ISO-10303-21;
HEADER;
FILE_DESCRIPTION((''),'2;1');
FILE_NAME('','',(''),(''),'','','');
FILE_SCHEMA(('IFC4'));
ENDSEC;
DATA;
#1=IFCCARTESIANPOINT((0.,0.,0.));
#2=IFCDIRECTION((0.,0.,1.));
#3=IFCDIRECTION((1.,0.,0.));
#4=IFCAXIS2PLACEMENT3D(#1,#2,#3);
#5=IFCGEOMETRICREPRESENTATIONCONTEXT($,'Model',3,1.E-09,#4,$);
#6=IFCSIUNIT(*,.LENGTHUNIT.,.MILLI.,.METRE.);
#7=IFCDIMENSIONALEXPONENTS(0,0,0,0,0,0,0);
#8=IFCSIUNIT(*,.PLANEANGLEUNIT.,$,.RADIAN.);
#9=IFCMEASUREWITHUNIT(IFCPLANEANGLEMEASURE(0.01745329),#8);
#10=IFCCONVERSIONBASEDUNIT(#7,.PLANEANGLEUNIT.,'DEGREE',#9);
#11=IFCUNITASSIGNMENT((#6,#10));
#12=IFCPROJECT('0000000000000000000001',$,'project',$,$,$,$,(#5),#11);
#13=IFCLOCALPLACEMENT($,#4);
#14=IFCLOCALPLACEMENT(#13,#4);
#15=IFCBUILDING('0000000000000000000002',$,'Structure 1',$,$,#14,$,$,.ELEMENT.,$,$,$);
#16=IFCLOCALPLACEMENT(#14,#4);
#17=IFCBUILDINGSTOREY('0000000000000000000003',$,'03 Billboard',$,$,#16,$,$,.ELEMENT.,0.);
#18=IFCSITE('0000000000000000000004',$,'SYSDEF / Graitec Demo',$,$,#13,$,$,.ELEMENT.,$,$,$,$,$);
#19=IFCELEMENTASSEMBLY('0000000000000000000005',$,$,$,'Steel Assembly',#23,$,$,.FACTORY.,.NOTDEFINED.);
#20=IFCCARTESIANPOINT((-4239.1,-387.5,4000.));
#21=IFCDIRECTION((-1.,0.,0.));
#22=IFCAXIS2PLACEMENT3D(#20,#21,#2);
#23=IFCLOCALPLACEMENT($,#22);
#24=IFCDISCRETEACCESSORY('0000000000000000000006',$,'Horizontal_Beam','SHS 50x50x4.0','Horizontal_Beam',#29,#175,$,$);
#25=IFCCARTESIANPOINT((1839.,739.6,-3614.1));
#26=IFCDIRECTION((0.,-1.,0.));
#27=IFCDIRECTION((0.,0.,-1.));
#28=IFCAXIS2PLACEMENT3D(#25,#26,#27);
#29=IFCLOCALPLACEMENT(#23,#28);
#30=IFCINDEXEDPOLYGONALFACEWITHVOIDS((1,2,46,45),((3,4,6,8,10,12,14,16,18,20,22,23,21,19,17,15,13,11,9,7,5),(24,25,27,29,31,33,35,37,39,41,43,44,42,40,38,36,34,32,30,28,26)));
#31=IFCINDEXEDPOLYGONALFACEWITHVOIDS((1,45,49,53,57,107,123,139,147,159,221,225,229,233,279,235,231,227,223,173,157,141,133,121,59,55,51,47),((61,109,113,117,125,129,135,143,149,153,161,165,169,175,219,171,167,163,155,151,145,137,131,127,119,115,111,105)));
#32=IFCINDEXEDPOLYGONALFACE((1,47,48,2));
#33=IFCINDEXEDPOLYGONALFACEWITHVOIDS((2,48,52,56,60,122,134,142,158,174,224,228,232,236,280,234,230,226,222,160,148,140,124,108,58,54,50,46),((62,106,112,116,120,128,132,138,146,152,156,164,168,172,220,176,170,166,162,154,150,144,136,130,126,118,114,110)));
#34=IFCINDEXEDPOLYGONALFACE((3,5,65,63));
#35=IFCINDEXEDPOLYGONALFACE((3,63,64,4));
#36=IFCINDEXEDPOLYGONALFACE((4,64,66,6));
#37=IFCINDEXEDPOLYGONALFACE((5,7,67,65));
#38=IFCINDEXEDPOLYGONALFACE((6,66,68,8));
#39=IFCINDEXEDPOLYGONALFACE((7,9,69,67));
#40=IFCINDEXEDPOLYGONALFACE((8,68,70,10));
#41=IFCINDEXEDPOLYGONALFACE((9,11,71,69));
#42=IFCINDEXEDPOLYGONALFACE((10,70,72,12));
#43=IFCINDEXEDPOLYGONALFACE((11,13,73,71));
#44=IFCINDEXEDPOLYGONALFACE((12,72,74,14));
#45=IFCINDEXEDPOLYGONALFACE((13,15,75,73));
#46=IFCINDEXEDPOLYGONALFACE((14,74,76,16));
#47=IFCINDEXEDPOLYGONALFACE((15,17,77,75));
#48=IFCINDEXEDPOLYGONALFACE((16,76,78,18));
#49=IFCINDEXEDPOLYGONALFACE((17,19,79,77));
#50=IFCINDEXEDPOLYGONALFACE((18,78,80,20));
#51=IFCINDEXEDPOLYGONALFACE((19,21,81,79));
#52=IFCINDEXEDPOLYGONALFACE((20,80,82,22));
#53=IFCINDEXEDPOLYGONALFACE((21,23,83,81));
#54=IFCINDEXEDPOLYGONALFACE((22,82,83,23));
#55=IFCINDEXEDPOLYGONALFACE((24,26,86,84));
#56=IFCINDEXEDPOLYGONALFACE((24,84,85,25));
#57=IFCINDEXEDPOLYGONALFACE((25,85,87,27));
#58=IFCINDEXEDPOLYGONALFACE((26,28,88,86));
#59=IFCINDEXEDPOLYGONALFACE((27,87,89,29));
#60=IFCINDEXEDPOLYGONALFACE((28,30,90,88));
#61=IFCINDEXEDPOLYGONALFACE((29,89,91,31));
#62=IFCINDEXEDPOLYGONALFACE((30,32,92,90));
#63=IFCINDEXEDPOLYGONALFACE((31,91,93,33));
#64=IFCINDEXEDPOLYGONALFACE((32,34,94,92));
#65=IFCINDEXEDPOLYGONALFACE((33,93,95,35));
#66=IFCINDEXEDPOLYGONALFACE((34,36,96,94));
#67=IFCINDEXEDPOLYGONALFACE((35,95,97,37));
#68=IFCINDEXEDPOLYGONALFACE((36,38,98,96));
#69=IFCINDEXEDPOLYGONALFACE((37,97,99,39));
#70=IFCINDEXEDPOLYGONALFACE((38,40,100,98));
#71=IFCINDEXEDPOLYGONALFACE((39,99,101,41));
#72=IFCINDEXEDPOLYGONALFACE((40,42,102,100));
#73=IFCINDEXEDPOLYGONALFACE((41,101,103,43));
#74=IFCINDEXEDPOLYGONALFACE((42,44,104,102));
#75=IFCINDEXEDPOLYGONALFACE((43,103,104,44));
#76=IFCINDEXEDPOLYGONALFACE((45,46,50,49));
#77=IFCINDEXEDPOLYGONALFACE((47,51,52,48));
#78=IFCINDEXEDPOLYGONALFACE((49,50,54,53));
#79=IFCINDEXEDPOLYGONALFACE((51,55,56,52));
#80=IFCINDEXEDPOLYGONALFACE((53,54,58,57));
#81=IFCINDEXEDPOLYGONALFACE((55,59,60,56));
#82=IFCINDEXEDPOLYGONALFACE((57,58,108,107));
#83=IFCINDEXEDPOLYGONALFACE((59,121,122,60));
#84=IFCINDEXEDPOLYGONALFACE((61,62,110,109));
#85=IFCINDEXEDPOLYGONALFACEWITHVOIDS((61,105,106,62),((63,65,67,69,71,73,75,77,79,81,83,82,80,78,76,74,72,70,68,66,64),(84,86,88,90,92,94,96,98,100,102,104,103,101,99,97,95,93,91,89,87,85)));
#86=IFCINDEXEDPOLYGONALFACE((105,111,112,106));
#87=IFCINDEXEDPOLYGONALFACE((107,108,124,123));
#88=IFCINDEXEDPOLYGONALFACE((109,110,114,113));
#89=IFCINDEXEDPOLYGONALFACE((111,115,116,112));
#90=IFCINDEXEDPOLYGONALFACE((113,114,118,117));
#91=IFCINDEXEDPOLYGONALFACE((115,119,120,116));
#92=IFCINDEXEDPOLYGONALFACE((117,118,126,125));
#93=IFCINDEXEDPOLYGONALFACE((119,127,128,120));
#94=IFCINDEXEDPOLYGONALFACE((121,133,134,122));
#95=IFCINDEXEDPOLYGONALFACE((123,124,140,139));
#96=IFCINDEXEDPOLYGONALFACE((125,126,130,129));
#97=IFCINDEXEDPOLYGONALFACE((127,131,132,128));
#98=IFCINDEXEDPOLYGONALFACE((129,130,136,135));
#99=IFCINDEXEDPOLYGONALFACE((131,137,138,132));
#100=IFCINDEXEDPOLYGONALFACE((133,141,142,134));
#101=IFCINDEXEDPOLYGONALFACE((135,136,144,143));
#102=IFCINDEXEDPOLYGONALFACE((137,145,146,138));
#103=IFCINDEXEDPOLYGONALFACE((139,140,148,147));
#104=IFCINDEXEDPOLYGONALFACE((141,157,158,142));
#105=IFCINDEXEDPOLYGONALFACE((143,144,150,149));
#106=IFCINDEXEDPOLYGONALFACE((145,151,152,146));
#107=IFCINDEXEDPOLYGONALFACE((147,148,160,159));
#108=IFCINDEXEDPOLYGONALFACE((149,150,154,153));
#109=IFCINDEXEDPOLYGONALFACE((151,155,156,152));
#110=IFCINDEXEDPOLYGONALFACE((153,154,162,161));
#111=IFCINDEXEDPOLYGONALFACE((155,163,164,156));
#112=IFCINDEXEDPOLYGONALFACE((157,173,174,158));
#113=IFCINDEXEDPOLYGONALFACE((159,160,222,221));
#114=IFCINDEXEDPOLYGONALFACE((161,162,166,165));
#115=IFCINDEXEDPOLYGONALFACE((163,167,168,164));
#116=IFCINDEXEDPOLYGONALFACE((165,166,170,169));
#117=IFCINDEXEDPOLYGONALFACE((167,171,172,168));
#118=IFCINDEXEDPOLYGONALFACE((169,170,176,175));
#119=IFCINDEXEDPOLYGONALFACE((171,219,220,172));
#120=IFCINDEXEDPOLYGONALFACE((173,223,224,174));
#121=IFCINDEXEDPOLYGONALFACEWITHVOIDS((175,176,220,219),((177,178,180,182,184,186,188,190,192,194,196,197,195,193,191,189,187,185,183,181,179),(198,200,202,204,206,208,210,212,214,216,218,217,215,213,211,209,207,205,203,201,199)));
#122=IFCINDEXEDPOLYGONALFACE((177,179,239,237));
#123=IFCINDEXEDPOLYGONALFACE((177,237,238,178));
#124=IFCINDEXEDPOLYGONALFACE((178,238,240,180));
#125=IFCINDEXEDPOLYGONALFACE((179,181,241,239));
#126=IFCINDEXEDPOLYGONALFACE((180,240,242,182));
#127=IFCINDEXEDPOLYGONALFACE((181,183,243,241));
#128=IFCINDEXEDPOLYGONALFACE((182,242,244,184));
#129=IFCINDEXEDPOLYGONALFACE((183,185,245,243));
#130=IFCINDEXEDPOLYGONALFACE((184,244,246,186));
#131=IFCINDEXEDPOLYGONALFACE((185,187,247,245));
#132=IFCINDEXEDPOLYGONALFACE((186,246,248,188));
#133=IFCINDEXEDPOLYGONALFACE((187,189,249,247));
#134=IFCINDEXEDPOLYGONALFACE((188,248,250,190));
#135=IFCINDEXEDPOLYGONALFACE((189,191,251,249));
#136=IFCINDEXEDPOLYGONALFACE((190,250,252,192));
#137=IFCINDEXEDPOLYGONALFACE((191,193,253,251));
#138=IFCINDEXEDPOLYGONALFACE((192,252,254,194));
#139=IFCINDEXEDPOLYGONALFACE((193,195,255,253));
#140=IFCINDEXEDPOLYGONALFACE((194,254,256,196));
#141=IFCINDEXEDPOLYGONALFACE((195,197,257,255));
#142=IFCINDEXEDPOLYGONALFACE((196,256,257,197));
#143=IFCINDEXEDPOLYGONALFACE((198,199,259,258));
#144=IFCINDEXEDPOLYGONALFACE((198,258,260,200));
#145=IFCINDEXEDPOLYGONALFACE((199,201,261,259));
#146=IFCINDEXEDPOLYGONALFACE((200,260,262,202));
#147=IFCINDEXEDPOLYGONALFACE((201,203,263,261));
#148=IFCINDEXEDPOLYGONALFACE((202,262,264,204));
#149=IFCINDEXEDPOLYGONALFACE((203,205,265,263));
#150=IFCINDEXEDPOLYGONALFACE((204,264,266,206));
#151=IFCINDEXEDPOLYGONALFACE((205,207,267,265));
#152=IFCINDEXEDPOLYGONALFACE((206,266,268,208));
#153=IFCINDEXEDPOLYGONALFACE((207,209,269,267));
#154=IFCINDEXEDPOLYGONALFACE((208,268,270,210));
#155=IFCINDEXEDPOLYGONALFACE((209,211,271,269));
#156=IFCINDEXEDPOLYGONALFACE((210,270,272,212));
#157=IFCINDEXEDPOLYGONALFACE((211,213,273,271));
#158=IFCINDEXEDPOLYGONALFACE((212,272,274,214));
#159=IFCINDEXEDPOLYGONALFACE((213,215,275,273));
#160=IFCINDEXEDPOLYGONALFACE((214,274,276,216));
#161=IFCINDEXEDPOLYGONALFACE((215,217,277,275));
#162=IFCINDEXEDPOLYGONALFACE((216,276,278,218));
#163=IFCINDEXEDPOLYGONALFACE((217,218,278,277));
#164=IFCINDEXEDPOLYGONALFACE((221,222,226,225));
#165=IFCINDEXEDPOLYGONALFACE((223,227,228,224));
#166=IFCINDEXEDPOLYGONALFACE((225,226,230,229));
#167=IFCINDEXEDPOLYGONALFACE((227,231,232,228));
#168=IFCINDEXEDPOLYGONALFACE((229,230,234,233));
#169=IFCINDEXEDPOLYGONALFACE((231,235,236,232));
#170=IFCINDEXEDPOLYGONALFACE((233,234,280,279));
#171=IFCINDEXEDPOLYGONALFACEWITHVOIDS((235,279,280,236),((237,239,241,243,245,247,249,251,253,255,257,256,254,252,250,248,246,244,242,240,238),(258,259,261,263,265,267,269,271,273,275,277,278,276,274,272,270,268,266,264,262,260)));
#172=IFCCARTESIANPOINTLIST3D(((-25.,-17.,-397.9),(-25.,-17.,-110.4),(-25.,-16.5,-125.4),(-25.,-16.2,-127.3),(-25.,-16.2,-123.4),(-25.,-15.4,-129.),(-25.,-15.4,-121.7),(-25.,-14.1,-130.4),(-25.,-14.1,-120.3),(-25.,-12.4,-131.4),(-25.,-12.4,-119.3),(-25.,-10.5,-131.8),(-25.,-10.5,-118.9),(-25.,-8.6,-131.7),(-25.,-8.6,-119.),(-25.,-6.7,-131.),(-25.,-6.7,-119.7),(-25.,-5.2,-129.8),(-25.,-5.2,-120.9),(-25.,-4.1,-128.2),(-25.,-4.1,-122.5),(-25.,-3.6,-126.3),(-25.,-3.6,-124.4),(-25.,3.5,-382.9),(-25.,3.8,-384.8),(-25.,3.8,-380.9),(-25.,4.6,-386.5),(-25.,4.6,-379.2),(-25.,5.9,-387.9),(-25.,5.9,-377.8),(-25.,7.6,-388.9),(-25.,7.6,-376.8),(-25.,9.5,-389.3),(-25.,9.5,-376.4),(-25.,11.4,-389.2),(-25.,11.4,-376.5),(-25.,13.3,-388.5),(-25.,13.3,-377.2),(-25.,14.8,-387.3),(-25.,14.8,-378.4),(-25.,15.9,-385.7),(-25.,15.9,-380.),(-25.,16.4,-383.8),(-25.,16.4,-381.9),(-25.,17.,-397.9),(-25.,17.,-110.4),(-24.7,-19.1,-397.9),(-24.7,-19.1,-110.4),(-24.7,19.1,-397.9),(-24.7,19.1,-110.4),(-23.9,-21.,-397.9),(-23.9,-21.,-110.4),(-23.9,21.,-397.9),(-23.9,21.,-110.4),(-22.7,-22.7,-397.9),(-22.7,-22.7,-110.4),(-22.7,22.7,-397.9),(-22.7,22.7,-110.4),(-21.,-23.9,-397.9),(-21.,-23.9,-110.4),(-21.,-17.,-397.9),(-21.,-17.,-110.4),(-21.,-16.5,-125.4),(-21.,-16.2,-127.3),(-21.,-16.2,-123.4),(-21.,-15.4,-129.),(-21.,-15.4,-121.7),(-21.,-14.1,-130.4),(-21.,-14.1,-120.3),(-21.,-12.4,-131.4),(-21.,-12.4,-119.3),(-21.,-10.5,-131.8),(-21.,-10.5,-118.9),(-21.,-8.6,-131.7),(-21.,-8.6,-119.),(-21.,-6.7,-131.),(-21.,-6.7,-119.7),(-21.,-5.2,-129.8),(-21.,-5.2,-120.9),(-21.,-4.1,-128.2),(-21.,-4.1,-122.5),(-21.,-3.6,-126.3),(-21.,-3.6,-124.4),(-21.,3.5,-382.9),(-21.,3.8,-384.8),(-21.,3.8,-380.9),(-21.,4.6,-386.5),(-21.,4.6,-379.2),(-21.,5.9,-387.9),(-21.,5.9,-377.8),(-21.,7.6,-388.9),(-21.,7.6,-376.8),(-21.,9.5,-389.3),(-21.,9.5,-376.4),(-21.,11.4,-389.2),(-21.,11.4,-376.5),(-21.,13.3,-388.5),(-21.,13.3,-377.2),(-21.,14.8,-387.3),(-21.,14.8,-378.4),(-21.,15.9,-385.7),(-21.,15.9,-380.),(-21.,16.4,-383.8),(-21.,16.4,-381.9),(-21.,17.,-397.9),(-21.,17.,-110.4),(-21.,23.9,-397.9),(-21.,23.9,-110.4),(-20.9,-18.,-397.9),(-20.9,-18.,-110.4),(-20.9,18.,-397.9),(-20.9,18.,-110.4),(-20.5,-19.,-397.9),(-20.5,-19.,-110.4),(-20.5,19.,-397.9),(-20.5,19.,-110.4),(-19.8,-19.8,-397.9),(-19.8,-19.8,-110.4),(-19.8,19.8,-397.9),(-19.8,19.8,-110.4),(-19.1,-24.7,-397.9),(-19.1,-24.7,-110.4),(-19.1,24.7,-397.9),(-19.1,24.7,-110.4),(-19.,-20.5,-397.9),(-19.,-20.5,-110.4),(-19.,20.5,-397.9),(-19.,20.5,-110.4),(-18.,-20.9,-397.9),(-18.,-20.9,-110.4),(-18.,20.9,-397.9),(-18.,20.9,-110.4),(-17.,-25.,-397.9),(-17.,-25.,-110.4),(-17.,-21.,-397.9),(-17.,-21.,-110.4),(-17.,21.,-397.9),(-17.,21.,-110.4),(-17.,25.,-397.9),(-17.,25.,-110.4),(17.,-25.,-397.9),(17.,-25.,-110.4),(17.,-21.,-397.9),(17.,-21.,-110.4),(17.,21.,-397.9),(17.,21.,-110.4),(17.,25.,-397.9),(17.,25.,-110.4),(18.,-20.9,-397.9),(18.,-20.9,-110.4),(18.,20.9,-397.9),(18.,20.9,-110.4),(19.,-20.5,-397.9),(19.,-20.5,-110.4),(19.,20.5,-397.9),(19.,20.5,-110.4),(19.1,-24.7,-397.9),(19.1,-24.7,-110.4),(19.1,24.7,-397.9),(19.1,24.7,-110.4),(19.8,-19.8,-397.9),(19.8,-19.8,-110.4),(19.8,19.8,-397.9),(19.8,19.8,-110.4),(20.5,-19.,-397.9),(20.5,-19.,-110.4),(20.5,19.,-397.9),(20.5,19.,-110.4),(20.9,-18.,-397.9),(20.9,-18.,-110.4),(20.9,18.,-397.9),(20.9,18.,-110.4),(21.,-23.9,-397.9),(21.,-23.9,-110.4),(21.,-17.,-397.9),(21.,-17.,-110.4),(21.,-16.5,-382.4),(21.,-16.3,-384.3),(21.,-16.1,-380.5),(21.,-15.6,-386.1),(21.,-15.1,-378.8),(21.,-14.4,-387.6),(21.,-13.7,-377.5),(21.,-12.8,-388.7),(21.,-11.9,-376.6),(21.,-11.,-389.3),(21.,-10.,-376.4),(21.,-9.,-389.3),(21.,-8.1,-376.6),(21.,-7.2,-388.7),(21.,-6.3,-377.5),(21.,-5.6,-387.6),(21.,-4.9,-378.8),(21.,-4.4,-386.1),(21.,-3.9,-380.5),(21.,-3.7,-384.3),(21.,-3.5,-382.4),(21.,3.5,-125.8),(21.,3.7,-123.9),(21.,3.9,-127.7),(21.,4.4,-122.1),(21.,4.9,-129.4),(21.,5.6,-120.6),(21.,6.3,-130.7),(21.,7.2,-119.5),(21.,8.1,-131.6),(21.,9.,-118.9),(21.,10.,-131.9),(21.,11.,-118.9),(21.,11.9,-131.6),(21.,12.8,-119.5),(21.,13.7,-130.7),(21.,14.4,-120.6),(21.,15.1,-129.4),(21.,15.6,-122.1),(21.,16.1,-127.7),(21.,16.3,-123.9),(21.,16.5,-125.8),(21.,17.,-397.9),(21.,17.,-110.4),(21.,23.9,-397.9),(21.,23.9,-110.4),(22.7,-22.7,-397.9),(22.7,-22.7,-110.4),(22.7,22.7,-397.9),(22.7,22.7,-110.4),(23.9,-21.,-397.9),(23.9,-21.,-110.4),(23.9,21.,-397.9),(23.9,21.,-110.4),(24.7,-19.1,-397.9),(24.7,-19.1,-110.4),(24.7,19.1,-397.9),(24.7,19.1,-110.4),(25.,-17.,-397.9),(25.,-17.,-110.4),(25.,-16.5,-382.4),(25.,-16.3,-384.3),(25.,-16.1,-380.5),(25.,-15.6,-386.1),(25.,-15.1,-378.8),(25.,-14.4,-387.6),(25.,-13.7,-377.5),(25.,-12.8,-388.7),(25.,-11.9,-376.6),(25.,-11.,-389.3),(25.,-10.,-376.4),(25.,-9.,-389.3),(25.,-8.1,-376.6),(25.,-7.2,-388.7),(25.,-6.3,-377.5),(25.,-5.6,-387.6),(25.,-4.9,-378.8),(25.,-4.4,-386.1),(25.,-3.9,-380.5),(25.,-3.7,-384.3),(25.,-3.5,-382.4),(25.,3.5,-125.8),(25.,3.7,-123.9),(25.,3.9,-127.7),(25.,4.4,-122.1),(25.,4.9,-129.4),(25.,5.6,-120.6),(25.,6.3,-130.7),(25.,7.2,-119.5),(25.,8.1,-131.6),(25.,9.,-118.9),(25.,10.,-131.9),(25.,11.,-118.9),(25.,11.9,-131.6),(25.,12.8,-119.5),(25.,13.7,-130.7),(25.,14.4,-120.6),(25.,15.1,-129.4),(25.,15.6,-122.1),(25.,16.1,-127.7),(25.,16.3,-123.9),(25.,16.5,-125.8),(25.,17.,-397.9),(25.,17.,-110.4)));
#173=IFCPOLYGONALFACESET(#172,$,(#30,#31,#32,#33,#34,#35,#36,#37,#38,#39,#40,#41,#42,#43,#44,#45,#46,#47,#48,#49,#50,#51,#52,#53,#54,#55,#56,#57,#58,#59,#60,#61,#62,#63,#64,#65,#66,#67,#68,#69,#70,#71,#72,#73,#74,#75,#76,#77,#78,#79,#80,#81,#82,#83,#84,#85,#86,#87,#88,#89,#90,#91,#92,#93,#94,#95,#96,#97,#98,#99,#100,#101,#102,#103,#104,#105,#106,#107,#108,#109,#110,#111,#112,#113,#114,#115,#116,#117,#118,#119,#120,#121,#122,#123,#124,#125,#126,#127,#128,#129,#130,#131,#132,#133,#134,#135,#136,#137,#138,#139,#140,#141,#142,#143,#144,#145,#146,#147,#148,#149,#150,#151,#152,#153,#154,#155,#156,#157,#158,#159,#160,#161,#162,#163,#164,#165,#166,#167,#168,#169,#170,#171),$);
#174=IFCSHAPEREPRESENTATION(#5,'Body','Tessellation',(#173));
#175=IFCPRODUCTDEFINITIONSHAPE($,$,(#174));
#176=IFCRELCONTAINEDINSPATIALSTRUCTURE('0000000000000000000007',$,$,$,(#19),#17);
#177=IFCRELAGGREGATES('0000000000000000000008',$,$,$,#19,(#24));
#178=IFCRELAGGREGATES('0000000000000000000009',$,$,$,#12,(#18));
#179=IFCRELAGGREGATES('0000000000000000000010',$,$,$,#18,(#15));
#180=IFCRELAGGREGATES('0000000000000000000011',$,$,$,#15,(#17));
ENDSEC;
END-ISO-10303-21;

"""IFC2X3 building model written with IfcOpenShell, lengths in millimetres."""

from ifc_helpers import new_model, entity, si_unit, converted_unit, frame, frame_2d, origin, origin_with_axes, origin_2d, origin_2d_with_axis, place, context, project, spatial, hollow_rectangle, circle, extrude, clip, halfspace, element, aggregate, save


model = new_model("IFC2X3")

# Units and contexts
model_context = context("Model", 3, precision=1e-09, world=origin_with_axes())
ifc_project = project(units=[si_unit("LENGTHUNIT", "METRE", prefix="MILLI"), converted_unit("PLANEANGLEUNIT", "DEGREE", entity("IfcPlaneAngleMeasure", 0.01745329), si_unit("PLANEANGLEUNIT", "RADIAN"), dimensions=[0, 0, 0, 0, 0, 0, 0])], contexts=[model_context])

# Site, building, storey
site_placement = place(None, origin_with_axes())
site = spatial("IfcSite", under=ifc_project, at=site_placement, Name="SYSDEF / Graitec Demo", CompositionType="ELEMENT")
building_placement = place(site_placement, origin_with_axes())
building = spatial("IfcBuilding", under=site, at=building_placement, Name="Structure 1", CompositionType="ELEMENT")
storey_placement = place(building_placement, origin_with_axes())
storey = spatial("IfcBuildingStorey", under=building, at=storey_placement, Name="03 Billboard", CompositionType="ELEMENT", Elevation=0.0)

# Element assembly, discrete accessory, openings
assembly_1_placement = place(None, frame((-4239.1, -387.5, 4000.0), z_axis=(-1.0, 0.0, 0.0), x_axis=(0.0, 0.0, 1.0)))
assembly_1 = element("IfcElementAssembly", 1, at=assembly_1_placement, inside=storey, ObjectType="Steel Assembly", AssemblyPlace="FACTORY", PredefinedType="NOTDEFINED")
discrete_accessory_1_placement = place(assembly_1_placement, frame((1839.0, 739.6, -3614.1), z_axis=(0.0, -1.0, 0.0), x_axis=(0.0, 0.0, -1.0)))
discrete_accessory_1 = element("IfcDiscreteAccessory", 2, at=discrete_accessory_1_placement, Name="Horizontal_Beam", Description="SHS 50x50x4.0", ObjectType="Horizontal_Beam", context=model_context, shape_type="Clipping", body=[
    clip(clip(extrude(hollow_rectangle(XDim=50.0, YDim=50.0, WallThickness=4.0, InnerFilletRadius=4.0, OuterFilletRadius=8.0, at=origin_2d()), origin(), (0.0, 0.0, -1.0), 483.2), halfspace(frame((625.0, -5839.0, -397.9), z_axis=(0.0, 0.0, 1.0), x_axis=(1.0, 0.0, 0.0)), True)), halfspace(frame((625.0, -5839.0, -110.4), z_axis=(0.0, 0.0, -1.0), x_axis=(-1.0, 0.0, 0.0)), True)),
])
opening_1_placement = place(discrete_accessory_1_placement, frame((20.5, -10.0, -382.9), z_axis=(1.0, 0.0, 0.0), x_axis=(0.0, 0.0, 1.0)))
element("IfcOpeningElement", 3, at=opening_1_placement, cuts=discrete_accessory_1, ObjectType="Opening", context=model_context, shape_type="SweptSolid", body=[
    extrude(circle(Radius=6.5, at=origin_2d_with_axis()), origin(), (0.0, 0.0, 1.0), 5.0),
])
opening_2_placement = place(discrete_accessory_1_placement, frame((20.5, 10.0, -125.4), z_axis=(1.0, 0.0, 0.0), x_axis=(0.0, 0.0, -1.0)))
element("IfcOpeningElement", 4, at=opening_2_placement, cuts=discrete_accessory_1, ObjectType="Opening", context=model_context, shape_type="SweptSolid", body=[
    extrude(circle(Radius=6.5, at=origin_2d_with_axis()), origin(), (0.0, 0.0, 1.0), 5.0),
])
opening_3_placement = place(discrete_accessory_1_placement, frame((-25.5, -10.0, -118.9), z_axis=(-1.0, 0.0, 0.0), x_axis=(0.0, -1.0, 0.0)))
element("IfcOpeningElement", 5, at=opening_3_placement, cuts=discrete_accessory_1, ObjectType="Opening", context=model_context, shape_type="SweptSolid", body=[
    extrude(circle(Radius=6.5, at=frame_2d((0.0, -6.5), x_axis=(1.0, 0.0))), origin(), (0.0, 0.0, -1.0), 5.0),
])
opening_4_placement = place(discrete_accessory_1_placement, frame((-25.5, 10.0, -389.4), z_axis=(-1.0, 0.0, 0.0), x_axis=(0.0, -1.0, 0.0)))
element("IfcOpeningElement", 6, at=opening_4_placement, cuts=discrete_accessory_1, ObjectType="Opening", context=model_context, shape_type="SweptSolid", body=[
    extrude(circle(Radius=6.5, at=frame_2d((0.0, 6.5), x_axis=(1.0, 0.0))), origin(), (0.0, 0.0, -1.0), 5.0),
])
aggregate(assembly_1, [discrete_accessory_1])

save(model, "model.ifc")
